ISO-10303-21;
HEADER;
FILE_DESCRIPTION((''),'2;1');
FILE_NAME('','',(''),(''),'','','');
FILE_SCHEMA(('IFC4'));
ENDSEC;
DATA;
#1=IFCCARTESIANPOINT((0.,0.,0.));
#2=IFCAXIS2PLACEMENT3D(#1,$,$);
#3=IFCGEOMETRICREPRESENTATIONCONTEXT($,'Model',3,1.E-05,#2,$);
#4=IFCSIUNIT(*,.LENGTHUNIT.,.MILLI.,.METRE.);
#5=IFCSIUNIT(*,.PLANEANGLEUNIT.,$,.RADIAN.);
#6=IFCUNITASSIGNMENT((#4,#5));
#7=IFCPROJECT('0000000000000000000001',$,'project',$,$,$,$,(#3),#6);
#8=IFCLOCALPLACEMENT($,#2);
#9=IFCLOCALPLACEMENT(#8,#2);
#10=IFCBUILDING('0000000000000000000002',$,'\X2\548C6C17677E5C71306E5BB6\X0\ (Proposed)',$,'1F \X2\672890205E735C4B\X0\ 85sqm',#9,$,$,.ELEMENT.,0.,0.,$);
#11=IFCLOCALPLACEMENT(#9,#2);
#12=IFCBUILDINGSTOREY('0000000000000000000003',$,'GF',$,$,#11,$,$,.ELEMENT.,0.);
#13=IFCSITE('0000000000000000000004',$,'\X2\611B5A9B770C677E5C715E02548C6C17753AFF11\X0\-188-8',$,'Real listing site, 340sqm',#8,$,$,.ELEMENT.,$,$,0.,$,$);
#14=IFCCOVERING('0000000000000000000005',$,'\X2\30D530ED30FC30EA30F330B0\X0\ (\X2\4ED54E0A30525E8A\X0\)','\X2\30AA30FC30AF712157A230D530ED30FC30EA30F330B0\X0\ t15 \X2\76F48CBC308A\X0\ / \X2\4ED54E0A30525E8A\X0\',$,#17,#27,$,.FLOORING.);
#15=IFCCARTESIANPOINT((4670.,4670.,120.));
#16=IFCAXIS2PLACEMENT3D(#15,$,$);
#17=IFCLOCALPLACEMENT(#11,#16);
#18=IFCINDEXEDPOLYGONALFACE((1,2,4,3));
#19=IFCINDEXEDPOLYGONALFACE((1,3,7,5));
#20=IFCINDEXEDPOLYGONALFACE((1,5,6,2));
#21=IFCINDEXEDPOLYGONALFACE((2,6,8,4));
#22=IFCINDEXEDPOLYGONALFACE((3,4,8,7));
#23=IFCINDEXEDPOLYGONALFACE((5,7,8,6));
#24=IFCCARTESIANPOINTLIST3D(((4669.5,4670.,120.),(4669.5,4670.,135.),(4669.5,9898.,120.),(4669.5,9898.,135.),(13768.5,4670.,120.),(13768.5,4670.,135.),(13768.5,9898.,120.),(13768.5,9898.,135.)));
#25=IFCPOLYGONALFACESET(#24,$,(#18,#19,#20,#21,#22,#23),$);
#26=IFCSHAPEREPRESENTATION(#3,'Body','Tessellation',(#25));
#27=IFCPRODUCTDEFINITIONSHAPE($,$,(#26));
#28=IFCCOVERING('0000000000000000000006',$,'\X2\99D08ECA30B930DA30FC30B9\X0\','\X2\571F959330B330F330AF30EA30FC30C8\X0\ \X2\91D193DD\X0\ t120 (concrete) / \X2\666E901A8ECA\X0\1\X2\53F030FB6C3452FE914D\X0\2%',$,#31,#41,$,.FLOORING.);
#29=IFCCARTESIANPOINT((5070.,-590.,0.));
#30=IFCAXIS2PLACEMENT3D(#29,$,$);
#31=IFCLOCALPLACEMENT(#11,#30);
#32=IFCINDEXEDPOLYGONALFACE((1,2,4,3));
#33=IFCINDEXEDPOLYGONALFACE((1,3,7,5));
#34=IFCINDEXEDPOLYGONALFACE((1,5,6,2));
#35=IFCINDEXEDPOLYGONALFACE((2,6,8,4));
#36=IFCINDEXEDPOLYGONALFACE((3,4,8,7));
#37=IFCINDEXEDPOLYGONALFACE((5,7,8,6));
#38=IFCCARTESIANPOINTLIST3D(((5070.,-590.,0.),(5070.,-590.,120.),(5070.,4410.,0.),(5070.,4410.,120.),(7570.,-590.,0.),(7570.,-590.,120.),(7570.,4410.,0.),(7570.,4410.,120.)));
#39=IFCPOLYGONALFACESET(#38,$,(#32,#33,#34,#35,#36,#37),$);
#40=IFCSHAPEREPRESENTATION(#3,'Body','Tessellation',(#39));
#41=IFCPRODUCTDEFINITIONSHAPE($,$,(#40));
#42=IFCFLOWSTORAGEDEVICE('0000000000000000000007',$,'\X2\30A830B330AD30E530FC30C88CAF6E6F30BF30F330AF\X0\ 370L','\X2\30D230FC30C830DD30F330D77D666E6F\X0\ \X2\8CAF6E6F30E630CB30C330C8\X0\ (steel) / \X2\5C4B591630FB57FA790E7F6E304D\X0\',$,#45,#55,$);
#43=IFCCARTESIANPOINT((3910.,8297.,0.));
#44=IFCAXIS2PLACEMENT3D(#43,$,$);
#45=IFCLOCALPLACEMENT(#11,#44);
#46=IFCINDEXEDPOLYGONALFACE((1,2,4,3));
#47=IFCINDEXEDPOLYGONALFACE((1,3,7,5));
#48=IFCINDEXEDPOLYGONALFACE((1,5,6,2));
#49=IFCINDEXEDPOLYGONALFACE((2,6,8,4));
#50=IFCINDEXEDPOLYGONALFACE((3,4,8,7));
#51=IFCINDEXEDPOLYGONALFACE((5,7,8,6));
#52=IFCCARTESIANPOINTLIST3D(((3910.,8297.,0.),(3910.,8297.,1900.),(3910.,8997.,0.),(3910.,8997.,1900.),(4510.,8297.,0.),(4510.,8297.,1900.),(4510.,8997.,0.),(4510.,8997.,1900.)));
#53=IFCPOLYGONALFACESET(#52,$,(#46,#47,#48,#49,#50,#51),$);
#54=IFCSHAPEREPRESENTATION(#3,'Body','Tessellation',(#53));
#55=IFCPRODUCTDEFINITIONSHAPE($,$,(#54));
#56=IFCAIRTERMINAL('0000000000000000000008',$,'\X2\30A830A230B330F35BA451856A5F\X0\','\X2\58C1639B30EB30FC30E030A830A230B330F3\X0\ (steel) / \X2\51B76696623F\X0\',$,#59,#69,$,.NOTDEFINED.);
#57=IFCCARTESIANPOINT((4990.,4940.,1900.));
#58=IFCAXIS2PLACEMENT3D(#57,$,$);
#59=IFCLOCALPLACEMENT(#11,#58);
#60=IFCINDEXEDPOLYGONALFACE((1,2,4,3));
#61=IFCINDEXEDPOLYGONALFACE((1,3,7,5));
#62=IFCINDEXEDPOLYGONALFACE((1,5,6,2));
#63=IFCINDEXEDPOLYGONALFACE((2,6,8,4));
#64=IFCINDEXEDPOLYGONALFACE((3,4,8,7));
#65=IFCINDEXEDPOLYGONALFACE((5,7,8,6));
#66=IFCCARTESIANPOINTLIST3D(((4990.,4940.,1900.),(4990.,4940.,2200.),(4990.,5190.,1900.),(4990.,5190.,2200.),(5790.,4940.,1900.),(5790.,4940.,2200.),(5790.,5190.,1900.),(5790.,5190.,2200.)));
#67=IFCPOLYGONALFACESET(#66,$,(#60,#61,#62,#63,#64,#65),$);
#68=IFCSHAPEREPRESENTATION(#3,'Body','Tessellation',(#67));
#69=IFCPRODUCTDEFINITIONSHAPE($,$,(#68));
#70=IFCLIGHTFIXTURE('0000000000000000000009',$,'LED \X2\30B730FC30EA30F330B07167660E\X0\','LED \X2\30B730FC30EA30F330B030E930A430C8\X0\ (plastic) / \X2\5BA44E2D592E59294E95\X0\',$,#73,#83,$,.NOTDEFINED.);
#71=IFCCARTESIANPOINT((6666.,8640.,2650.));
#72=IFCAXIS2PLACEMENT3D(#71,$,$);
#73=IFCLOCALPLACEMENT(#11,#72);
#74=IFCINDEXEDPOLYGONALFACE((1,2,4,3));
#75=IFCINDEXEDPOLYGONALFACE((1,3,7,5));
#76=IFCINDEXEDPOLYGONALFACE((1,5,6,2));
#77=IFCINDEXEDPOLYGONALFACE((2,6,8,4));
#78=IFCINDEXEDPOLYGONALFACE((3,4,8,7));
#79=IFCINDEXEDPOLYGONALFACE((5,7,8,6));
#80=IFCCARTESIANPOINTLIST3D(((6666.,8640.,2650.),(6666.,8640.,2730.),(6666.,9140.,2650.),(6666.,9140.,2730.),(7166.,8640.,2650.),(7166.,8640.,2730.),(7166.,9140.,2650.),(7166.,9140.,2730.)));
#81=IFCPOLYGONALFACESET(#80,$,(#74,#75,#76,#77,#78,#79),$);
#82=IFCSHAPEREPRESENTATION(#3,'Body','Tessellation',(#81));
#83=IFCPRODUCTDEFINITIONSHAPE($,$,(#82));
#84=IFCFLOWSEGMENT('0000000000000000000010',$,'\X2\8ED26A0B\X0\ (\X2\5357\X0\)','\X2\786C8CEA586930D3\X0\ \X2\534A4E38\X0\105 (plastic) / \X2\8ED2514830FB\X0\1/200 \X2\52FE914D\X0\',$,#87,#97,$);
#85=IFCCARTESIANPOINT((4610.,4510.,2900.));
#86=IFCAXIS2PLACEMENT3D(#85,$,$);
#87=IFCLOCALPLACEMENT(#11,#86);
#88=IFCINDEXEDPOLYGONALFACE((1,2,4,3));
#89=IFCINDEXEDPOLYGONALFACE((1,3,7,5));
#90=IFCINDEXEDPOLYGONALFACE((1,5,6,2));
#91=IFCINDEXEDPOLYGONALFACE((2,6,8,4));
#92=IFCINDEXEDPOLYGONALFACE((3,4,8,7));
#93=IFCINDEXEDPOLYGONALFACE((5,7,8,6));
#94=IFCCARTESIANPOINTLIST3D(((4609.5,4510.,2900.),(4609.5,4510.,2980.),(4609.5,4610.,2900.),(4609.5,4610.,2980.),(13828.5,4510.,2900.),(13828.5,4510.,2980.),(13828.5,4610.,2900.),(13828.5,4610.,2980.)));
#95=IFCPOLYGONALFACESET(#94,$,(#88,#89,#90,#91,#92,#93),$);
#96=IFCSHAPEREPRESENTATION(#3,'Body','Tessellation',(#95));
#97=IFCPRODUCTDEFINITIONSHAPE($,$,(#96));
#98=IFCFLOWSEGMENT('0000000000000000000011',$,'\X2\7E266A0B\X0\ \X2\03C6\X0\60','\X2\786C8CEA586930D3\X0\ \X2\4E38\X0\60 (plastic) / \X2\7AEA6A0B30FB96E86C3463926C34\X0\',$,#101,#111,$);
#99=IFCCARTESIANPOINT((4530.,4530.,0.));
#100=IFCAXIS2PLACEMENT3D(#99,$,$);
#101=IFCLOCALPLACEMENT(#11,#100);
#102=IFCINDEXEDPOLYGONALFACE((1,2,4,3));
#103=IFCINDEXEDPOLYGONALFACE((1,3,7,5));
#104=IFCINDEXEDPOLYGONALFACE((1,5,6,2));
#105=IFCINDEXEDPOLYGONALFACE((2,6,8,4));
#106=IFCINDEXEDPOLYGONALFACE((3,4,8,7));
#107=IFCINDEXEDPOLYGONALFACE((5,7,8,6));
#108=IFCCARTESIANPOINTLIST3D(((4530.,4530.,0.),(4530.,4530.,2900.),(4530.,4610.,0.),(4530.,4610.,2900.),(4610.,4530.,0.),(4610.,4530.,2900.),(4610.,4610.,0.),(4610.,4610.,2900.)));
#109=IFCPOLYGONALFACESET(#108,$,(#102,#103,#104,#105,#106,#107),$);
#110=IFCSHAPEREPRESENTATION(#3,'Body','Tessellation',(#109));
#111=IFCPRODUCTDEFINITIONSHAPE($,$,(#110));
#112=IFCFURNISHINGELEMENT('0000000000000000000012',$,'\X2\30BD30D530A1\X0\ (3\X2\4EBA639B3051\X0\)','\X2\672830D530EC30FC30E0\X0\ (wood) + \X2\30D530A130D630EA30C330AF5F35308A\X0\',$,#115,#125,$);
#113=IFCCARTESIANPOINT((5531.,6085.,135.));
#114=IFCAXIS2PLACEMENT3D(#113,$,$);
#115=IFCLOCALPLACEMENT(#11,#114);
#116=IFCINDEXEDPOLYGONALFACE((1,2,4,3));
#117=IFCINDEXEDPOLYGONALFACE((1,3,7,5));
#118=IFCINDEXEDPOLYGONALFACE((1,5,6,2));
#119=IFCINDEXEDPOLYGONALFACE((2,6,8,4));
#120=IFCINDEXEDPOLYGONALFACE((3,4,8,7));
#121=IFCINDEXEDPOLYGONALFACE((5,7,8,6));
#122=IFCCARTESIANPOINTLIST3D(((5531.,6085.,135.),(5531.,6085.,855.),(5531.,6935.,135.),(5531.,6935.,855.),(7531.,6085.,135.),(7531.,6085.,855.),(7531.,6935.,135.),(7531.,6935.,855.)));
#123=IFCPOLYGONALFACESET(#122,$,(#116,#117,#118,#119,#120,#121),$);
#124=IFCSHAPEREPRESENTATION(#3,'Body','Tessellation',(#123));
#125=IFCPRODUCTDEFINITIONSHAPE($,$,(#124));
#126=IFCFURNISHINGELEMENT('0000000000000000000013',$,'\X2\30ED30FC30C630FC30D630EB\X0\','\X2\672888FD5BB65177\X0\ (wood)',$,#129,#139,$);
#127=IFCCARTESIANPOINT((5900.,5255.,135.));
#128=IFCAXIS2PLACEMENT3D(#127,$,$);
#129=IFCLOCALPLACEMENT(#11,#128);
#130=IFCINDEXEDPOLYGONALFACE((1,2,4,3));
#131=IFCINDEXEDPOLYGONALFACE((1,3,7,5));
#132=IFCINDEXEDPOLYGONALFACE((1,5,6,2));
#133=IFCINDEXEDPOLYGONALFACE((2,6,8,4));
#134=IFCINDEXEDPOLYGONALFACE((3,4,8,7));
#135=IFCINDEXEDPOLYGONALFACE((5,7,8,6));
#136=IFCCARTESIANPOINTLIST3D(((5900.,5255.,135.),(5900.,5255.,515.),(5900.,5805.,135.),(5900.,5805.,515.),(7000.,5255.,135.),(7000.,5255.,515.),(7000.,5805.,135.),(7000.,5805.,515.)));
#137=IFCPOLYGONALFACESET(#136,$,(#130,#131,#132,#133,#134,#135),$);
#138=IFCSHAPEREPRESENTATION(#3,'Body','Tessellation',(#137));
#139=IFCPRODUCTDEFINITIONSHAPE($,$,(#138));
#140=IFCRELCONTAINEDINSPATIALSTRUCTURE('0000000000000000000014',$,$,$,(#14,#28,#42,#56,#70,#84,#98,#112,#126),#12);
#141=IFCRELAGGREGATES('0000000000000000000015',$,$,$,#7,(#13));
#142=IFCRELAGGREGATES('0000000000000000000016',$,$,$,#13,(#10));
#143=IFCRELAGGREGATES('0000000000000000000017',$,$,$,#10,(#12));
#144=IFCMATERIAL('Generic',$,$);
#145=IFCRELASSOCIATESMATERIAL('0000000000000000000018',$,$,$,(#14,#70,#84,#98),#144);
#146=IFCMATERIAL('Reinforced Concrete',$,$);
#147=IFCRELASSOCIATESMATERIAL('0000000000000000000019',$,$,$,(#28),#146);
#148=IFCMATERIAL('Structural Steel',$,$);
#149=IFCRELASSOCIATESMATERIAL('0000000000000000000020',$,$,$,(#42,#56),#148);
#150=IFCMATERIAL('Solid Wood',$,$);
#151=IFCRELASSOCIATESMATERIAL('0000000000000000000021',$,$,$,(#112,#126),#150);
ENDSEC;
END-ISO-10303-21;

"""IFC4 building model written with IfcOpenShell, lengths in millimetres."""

from ifc_helpers import new_model, si_unit, frame, frame_2d, origin, place, context, project, spatial, rectangle, extrude, material, element, save


model = new_model("IFC4")

# Units and contexts
model_context = context("Model", 3, precision=1e-05, world=origin())
ifc_project = project(units=[si_unit("LENGTHUNIT", "METRE", prefix="MILLI"), si_unit("PLANEANGLEUNIT", "RADIAN")], contexts=[model_context])

# Site, building, storey
site_placement = place(None, origin())
site = spatial("IfcSite", under=ifc_project, at=site_placement, Name="愛媛県松山市和気町１-188-8", ObjectType="Real listing site, 340sqm", CompositionType="ELEMENT", RefElevation=0.0)
building_placement = place(site_placement, origin())
building = spatial("IfcBuilding", under=site, at=building_placement, Name="和気松山の家 (Proposed)", ObjectType="1F 木造平屋 85sqm", CompositionType="ELEMENT", ElevationOfRefHeight=0.0, ElevationOfTerrain=0.0)
storey_placement = place(building_placement, origin())
storey = spatial("IfcBuildingStorey", under=building, at=storey_placement, Name="GF", CompositionType="ELEMENT", Elevation=0.0)

# Shared definitions
ifc_material_1 = material(Name="Solid Wood")

# Shared definitions
ifc_material_2 = material(Name="Reinforced Concrete")

# Shared definitions
ifc_material_3 = material(Name="Structural Steel")

# Coverings
ifc_material_4 = material(Name="Generic")
covering_1_placement = place(storey_placement, frame((4670.0, 4670.0, 120.0)))
element("IfcCovering", 1, at=covering_1_placement, inside=storey, material=ifc_material_4, Name="フローリング (仕上げ床)", Description="オーク無垢フローリング t15 直貼り / 仕上げ床", PredefinedType="FLOORING", context=model_context, shape_type="SweptSolid", body=[
    extrude(rectangle(XDim=9099.0, YDim=5228.0, at=frame_2d((4549.0, 2614.0))), frame((4670.0, 4670.0, 120.0)), (0.0, 0.0, 1.0), 15.0),
])
covering_2_placement = place(storey_placement, frame((5070.0, -590.0, 0.0)))
element("IfcCovering", 2, at=covering_2_placement, inside=storey, material=ifc_material_2, Name="駐車スペース", Description="土間コンクリート 金鏝 t120 (concrete) / 普通車1台・水勾配2%", PredefinedType="FLOORING", context=model_context, shape_type="SweptSolid", body=[
    extrude(rectangle(XDim=2500.0, YDim=5000.0, at=frame_2d((1250.0, 2500.0))), frame((5070.0, -590.0, 0.0)), (0.0, 0.0, 1.0), 120.0),
])

# Flow storage device
flow_storage_device_placement = place(storey_placement, frame((3910.0, 8297.0, 0.0)))
element("IfcFlowStorageDevice", 3, at=flow_storage_device_placement, inside=storey, material=ifc_material_3, Name="エコキュート貯湯タンク 370L", Description="ヒートポンプ給湯 貯湯ユニット (steel) / 屋外・基礎置き", context=model_context, shape_type="SweptSolid", body=[
    extrude(rectangle(XDim=600.0, YDim=700.0, at=frame_2d((300.0, 350.0))), frame((3910.0, 8297.0, 0.0)), (0.0, 0.0, 1.0), 1900.0),
])

# Air terminal
air_terminal_placement = place(storey_placement, frame((4990.0, 4940.0, 1900.0)))
element("IfcAirTerminal", 4, at=air_terminal_placement, inside=storey, material=ifc_material_3, Name="エアコン室内機", Description="壁掛ルームエアコン (steel) / 冷暖房", PredefinedType="NOTDEFINED", context=model_context, shape_type="SweptSolid", body=[
    extrude(rectangle(XDim=800.0, YDim=250.0, at=frame_2d((400.0, 125.0))), frame((4990.0, 4940.0, 1900.0)), (0.0, 0.0, 1.0), 300.0),
])

# Light fixture
light_fixture_placement = place(storey_placement, frame((6666.0, 8640.0, 2650.0)))
element("IfcLightFixture", 5, at=light_fixture_placement, inside=storey, material=ifc_material_4, Name="LED シーリング照明", Description="LED シーリングライト (plastic) / 室中央天井", PredefinedType="NOTDEFINED", context=model_context, shape_type="SweptSolid", body=[
    extrude(rectangle(XDim=500.0, YDim=500.0, at=frame_2d((250.0, 250.0))), frame((6666.0, 8640.0, 2650.0)), (0.0, 0.0, 1.0), 80.0),
])

# Flow segments
flow_segment_1_placement = place(storey_placement, frame((4610.0, 4510.0, 2900.0)))
element("IfcFlowSegment", 6, at=flow_segment_1_placement, inside=storey, material=ifc_material_4, Name="軒樋 (南)", Description="硬質塩ビ 半丸105 (plastic) / 軒先・1/200 勾配", context=model_context, shape_type="SweptSolid", body=[
    extrude(rectangle(XDim=9219.0, YDim=100.0, at=frame_2d((4609.0, 50.0))), frame((4610.0, 4510.0, 2900.0)), (0.0, 0.0, 1.0), 80.0),
])
flow_segment_2_placement = place(storey_placement, frame((4530.0, 4530.0, 0.0)))
element("IfcFlowSegment", 7, at=flow_segment_2_placement, inside=storey, material=ifc_material_4, Name="縦樋 φ60", Description="硬質塩ビ 丸60 (plastic) / 竪樋・雨水排水", context=model_context, shape_type="SweptSolid", body=[
    extrude(rectangle(XDim=80.0, YDim=80.0, at=frame_2d((40.0, 40.0))), frame((4530.0, 4530.0, 0.0)), (0.0, 0.0, 1.0), 2900.0),
])

# Furnishing elements
furnishing_1_placement = place(storey_placement, frame((5531.0, 6085.0, 135.0)))
element("IfcFurnishingElement", 8, at=furnishing_1_placement, inside=storey, material=ifc_material_1, Name="ソファ (3人掛け)", Description="木フレーム (wood) + ファブリック張り", context=model_context, shape_type="SweptSolid", body=[
    extrude(rectangle(XDim=2000.0, YDim=850.0, at=frame_2d((1000.0, 425.0))), frame((5531.0, 6085.0, 135.0)), (0.0, 0.0, 1.0), 720.0),
])
furnishing_2_placement = place(storey_placement, frame((5900.0, 5255.0, 135.0)))
element("IfcFurnishingElement", 9, at=furnishing_2_placement, inside=storey, material=ifc_material_1, Name="ローテーブル", Description="木製家具 (wood)", context=model_context, shape_type="SweptSolid", body=[
    extrude(rectangle(XDim=1100.0, YDim=550.0, at=frame_2d((550.0, 275.0))), frame((5900.0, 5255.0, 135.0)), (0.0, 0.0, 1.0), 380.0),
])

save(model, "model.ifc")
